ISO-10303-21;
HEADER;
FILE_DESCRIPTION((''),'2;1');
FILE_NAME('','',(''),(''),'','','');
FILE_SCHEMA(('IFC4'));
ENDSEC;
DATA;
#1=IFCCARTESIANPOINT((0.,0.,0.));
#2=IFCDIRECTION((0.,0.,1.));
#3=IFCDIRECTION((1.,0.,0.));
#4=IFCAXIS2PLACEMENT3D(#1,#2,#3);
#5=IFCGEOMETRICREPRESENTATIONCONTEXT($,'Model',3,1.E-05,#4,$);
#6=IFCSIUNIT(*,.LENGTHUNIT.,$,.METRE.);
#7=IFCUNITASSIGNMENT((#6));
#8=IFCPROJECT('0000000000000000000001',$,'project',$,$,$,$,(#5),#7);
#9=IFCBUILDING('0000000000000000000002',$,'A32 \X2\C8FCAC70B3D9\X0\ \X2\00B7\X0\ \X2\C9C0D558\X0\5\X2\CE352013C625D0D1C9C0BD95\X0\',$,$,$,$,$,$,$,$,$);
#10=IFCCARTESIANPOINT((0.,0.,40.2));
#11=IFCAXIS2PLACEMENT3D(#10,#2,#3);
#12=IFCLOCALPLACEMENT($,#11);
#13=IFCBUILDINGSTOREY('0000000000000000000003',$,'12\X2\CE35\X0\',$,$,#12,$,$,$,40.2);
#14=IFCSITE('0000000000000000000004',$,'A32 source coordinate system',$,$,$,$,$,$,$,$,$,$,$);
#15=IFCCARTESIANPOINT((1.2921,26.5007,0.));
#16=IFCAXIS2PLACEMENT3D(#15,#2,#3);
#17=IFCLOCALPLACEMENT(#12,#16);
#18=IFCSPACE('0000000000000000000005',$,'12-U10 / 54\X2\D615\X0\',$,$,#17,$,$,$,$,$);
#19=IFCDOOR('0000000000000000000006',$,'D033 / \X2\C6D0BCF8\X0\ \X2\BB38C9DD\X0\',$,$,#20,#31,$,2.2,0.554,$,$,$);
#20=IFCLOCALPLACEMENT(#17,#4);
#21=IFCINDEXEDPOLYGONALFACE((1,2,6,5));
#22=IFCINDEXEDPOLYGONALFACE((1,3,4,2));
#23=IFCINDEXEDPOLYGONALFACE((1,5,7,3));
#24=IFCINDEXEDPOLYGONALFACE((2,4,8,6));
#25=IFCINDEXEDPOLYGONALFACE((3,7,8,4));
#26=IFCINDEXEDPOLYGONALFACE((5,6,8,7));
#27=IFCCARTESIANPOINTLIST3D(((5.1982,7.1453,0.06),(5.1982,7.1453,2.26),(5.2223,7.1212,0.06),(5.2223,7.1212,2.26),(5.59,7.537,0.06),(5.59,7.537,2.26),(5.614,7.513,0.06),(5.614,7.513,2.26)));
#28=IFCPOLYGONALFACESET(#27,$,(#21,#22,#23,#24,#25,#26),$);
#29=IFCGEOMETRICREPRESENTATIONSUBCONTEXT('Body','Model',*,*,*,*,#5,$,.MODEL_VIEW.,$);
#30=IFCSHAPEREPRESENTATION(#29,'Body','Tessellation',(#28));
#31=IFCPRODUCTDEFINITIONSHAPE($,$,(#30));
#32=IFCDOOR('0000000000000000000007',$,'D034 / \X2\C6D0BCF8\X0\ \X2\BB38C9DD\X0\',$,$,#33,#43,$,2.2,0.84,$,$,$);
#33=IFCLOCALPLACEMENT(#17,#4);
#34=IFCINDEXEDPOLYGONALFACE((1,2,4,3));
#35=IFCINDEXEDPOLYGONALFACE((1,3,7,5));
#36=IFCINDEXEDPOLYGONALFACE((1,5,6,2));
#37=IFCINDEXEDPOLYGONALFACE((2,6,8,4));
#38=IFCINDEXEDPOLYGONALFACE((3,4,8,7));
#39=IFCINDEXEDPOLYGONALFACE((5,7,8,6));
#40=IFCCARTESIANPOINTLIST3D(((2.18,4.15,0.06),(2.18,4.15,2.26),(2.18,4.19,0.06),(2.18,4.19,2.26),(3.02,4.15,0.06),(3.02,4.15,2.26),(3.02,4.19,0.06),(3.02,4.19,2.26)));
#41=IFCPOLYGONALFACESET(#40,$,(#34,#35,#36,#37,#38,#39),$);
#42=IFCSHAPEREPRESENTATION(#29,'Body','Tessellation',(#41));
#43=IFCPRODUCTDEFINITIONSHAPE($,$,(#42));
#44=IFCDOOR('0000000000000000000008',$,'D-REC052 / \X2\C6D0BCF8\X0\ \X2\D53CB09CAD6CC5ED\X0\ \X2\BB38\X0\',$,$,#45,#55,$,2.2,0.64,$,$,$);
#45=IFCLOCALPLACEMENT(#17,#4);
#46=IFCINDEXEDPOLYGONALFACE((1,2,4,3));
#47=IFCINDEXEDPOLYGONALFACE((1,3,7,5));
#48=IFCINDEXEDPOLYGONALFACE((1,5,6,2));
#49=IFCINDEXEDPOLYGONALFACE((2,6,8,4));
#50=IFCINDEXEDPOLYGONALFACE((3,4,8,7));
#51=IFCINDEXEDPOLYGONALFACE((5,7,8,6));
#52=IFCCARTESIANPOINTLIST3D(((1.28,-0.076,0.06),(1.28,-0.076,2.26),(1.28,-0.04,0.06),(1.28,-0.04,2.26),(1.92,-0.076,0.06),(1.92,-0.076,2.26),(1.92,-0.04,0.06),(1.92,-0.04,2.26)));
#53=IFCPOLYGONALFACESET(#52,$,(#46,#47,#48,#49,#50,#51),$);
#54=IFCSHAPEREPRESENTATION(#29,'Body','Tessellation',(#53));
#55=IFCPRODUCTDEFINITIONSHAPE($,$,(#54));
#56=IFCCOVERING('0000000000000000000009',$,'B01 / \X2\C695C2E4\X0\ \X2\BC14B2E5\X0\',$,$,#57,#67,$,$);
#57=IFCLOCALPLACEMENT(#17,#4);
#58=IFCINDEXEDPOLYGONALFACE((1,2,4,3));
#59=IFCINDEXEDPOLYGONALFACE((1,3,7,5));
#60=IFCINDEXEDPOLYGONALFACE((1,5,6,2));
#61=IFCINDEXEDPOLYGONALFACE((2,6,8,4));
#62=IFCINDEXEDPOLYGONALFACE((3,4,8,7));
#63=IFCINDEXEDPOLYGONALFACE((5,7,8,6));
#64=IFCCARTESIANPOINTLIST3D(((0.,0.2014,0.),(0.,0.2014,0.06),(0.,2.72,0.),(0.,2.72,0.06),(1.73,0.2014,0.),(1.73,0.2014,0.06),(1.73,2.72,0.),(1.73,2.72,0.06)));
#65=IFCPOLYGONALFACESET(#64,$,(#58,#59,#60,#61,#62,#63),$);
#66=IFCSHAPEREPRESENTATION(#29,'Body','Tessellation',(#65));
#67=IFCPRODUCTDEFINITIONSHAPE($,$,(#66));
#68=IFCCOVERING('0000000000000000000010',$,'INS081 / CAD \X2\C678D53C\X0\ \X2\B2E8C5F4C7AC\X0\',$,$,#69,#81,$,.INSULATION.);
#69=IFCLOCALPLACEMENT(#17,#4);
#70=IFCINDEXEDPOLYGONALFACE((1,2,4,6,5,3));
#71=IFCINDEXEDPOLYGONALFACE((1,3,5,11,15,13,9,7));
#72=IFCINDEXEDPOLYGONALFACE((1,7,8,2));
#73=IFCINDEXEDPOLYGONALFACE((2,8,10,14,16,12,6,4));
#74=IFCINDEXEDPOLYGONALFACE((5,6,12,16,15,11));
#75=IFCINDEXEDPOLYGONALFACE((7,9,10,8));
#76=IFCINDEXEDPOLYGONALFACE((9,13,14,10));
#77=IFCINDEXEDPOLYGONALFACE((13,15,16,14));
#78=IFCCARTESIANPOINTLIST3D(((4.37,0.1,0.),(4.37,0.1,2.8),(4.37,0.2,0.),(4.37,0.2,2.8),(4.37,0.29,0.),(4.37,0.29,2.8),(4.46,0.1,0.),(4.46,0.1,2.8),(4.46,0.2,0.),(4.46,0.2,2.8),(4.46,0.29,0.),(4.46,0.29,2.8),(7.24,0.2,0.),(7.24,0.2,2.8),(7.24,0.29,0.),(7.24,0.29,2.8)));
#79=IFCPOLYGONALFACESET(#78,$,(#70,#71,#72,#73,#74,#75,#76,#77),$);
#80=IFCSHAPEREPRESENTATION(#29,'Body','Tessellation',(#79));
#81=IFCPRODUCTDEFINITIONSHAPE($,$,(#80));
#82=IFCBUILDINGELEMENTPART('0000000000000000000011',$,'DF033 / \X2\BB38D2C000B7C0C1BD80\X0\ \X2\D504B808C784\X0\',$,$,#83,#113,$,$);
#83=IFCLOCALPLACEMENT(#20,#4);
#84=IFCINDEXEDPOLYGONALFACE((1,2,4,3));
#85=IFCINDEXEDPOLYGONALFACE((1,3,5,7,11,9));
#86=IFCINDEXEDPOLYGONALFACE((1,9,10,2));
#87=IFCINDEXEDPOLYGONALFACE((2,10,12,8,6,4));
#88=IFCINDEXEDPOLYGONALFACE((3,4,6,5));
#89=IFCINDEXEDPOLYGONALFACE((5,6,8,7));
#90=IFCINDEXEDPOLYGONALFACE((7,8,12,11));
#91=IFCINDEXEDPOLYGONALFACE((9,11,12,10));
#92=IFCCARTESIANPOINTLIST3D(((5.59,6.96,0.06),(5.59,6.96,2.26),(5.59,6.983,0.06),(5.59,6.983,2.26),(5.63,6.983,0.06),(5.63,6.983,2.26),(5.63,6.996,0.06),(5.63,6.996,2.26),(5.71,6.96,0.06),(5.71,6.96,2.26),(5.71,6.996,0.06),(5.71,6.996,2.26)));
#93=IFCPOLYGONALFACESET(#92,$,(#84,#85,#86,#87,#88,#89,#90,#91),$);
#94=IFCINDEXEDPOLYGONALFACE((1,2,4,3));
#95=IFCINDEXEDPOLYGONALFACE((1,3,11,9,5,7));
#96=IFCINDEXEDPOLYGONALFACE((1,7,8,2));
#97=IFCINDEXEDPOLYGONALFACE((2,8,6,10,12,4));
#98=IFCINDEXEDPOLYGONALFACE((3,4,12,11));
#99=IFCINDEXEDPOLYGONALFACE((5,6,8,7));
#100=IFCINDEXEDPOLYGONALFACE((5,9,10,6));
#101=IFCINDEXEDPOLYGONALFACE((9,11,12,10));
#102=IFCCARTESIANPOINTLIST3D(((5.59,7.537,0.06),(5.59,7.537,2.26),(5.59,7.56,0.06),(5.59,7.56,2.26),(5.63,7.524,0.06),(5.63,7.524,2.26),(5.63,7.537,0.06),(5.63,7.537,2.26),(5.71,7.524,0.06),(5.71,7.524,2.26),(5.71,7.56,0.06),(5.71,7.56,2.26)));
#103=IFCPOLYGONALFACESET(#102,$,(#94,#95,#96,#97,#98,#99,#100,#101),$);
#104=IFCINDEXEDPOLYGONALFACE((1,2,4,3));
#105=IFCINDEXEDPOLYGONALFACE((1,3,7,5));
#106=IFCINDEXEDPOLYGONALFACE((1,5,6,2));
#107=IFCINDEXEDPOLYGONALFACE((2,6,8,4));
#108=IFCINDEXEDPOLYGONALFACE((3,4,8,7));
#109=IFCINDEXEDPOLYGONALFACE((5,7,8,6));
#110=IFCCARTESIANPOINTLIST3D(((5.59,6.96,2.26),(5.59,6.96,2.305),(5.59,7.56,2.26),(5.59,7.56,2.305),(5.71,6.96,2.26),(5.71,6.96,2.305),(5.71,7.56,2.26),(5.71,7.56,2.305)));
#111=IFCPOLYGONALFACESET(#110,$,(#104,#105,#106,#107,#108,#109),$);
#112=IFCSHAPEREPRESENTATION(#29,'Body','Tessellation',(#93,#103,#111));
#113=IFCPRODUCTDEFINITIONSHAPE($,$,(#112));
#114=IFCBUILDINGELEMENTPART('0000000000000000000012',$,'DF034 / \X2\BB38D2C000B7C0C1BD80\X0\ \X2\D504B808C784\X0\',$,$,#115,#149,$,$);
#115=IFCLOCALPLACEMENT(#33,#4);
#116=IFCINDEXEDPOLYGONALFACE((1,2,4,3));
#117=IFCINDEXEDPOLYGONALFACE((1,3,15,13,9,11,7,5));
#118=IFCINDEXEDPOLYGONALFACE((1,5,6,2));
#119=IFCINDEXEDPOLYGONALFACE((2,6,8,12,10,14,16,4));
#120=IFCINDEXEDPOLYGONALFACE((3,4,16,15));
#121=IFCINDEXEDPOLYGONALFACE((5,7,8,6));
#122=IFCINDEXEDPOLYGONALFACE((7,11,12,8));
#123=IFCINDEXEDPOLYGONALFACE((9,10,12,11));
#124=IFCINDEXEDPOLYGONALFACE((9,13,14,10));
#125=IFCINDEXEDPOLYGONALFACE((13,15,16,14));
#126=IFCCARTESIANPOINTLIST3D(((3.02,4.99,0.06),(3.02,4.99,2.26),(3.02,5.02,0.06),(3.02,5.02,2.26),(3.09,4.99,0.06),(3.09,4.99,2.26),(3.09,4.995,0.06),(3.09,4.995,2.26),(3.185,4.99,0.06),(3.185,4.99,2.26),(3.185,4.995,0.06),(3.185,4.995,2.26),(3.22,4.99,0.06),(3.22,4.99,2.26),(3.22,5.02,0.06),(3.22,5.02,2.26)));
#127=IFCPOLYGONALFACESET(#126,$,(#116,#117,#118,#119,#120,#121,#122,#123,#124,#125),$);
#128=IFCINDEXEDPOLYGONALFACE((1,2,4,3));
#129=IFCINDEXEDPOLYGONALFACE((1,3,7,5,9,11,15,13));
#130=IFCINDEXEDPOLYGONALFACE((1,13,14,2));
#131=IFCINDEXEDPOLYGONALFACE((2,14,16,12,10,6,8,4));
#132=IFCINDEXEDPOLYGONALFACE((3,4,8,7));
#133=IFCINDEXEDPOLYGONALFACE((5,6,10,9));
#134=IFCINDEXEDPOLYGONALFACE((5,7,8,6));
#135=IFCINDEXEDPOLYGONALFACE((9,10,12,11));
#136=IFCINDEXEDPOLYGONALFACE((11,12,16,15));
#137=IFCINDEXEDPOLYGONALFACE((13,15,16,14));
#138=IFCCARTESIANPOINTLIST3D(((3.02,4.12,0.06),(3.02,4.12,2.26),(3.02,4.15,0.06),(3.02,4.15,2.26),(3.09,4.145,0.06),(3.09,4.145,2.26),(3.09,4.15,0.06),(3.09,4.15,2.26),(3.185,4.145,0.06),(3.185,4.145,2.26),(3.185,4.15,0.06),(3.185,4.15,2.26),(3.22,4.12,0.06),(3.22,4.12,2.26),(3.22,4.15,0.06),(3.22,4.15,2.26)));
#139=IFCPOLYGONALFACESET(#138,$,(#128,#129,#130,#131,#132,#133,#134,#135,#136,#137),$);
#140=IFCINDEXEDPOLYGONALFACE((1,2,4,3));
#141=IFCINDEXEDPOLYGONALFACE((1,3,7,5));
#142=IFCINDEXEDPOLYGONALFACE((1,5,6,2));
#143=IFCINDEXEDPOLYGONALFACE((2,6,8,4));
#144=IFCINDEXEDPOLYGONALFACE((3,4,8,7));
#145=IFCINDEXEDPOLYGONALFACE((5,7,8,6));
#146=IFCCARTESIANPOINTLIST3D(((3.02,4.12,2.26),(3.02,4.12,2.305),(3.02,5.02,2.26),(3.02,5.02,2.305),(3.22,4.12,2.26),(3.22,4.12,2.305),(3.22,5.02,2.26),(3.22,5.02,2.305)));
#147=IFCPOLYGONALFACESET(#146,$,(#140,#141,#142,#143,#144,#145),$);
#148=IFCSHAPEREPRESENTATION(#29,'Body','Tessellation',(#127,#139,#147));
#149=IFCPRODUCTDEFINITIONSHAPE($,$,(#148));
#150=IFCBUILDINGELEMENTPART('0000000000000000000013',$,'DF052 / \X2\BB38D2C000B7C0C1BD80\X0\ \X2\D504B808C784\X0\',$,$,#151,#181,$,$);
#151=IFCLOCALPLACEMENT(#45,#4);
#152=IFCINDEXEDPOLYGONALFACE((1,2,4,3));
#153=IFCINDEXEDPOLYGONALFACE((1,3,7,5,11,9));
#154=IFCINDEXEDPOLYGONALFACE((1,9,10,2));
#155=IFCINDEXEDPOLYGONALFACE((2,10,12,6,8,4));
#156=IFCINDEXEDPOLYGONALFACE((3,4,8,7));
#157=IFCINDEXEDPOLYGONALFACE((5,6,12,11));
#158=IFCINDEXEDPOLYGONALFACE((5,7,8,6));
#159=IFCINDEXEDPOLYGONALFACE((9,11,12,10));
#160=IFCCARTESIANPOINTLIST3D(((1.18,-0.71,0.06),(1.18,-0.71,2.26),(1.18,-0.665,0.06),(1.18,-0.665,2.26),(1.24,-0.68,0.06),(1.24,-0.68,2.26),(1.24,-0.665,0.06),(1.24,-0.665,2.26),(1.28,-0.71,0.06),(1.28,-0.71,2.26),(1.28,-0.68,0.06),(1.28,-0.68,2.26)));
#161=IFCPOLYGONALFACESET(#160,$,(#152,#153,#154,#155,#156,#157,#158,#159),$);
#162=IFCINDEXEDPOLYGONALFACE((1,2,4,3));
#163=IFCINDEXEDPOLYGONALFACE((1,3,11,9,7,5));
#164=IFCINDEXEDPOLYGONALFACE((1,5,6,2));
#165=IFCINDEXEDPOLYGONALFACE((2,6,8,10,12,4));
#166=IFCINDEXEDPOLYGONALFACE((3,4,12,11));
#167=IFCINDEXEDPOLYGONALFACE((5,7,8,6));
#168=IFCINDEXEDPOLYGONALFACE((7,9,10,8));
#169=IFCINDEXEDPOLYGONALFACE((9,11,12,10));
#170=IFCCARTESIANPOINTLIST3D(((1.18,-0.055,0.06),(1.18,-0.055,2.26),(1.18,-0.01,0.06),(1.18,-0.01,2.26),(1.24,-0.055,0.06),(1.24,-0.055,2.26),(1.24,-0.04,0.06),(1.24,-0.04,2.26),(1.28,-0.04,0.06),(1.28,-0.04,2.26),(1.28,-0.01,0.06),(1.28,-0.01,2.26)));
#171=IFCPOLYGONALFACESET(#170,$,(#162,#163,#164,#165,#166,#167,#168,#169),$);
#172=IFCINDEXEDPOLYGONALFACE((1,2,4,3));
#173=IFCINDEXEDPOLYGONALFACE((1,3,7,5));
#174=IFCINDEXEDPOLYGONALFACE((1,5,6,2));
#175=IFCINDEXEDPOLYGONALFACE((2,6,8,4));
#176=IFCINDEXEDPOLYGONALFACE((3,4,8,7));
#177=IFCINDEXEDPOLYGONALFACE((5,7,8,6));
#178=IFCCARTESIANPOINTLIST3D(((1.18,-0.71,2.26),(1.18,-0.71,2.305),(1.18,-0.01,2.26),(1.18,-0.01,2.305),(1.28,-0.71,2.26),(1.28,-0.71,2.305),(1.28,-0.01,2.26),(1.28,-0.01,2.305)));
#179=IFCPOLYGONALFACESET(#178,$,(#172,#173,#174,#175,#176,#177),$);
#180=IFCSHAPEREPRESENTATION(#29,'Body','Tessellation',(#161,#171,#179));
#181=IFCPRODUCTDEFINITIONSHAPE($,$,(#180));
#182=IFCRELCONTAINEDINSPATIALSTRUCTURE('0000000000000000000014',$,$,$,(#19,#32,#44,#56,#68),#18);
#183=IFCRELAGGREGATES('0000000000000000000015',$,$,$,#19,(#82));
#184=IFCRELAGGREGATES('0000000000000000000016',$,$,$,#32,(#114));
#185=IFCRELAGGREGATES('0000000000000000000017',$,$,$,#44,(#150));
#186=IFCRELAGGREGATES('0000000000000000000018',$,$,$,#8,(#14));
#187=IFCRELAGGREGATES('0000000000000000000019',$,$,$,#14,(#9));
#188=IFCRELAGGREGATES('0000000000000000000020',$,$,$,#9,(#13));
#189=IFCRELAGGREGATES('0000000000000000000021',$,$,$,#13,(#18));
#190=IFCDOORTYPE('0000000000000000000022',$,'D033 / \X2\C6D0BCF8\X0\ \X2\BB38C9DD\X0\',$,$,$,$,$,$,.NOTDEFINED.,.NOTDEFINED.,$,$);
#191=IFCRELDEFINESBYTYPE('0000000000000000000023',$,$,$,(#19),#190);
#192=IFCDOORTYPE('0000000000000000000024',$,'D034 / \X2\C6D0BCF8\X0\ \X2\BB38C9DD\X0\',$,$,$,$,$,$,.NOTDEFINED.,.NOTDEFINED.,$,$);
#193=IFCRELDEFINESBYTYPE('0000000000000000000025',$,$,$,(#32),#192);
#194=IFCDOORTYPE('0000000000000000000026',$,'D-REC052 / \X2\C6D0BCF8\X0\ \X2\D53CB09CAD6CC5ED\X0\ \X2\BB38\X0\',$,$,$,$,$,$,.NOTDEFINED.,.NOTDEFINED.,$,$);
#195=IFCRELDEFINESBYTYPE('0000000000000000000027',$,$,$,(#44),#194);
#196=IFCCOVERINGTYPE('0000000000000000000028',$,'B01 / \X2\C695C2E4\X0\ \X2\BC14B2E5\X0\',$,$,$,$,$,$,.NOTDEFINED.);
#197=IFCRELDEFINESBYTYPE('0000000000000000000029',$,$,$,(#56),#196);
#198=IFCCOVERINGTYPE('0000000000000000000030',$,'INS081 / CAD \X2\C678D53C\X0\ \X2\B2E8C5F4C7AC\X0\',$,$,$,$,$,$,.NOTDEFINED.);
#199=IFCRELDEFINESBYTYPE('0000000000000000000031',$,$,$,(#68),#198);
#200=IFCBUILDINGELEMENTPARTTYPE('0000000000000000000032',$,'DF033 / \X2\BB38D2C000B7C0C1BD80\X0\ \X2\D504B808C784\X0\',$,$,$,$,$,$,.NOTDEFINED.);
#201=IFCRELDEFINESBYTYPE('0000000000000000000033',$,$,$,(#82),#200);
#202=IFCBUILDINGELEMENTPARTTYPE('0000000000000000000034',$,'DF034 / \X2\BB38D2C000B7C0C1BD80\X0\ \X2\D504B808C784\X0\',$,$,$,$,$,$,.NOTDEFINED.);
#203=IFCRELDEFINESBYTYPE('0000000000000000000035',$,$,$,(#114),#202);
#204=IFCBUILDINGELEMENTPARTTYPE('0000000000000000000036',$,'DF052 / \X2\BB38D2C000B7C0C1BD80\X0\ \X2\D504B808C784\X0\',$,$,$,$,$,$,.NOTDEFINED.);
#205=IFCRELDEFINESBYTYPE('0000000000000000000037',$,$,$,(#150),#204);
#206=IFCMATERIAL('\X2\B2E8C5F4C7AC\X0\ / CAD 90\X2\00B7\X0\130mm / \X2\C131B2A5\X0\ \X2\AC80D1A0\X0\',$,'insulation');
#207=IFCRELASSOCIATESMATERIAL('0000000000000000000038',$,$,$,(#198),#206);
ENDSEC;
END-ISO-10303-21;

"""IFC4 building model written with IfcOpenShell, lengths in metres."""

from ifc_helpers import new_model, si_unit, frame, origin, origin_with_axes, place, context, subcontext, project, spatial, polyline, outline, extrude, source, transform, mapped, material, type_object, type_shapes, element, aggregate, save


model = new_model("IFC4")

# Units and contexts
model_context = context("Model", 3, precision=1e-05, world=origin_with_axes())
body_context = subcontext(model_context, "Body", "Model", "MODEL_VIEW")
ifc_project = project(units=[si_unit("LENGTHUNIT", "METRE")], contexts=[model_context])

# Site, building, storey, space
storey_placement = place(None, frame((0.0, 0.0, 40.2), z_axis=(0.0, 0.0, 1.0), x_axis=(1.0, 0.0, 0.0)))
space_placement = place(storey_placement, frame((1.2921, 26.5007, 0.0), z_axis=(0.0, 0.0, 1.0), x_axis=(1.0, 0.0, 0.0)))
site = spatial("IfcSite", under=ifc_project, Name="A32 source coordinate system")
building = spatial("IfcBuilding", under=site, Name="A32 주거동 · 지하5층–옥탑지붕")
storey = spatial("IfcBuildingStorey", under=building, at=storey_placement, Name="12층", Elevation=40.2)
space = spatial("IfcSpace", under=storey, at=space_placement, Name="12-U10 / 54형")

# Doors
door_type_1 = type_object("IfcDoorType", Name="D033 / 원본 문짝", OperationType="NOTDEFINED", PredefinedType="NOTDEFINED")
shared_shape_1 = source(origin(), body_context, "Body", "SweptSolid", [
    extrude(outline(polyline([(5.2223, 7.1212), (5.1982, 7.1453), (5.59, 7.537), (5.614, 7.513), (5.2223, 7.1212)])), frame((0.0, 0.0, 0.06)), (0.0, 0.0, 1.0), 2.2),
])
type_shapes(door_type_1, [shared_shape_1])
door_1_placement = place(space_placement, origin_with_axes())
door_1 = element("IfcDoor", 1, at=door_1_placement, inside=space, type_object=door_type_1, Name="D033 / 원본 문짝", OverallHeight=2.2, OverallWidth=0.554, context=body_context, shape_type="MappedRepresentation", body=[
    mapped(shared_shape_1, transform((0.0, 0.0, 0.0), scale=1.0)),
])
door_type_2 = type_object("IfcDoorType", Name="D034 / 원본 문짝", OperationType="NOTDEFINED", PredefinedType="NOTDEFINED")
shared_shape_2 = source(origin(), body_context, "Body", "SweptSolid", [
    extrude(outline(polyline([(3.02, 4.15), (2.18, 4.15), (2.18, 4.19), (3.02, 4.19), (3.02, 4.15)])), frame((0.0, 0.0, 0.06)), (0.0, 0.0, 1.0), 2.2),
])
type_shapes(door_type_2, [shared_shape_2])
door_2_placement = place(space_placement, origin_with_axes())
door_2 = element("IfcDoor", 2, at=door_2_placement, inside=space, type_object=door_type_2, Name="D034 / 원본 문짝", OverallHeight=2.2, OverallWidth=0.84, context=body_context, shape_type="MappedRepresentation", body=[
    mapped(shared_shape_2, transform((0.0, 0.0, 0.0), scale=1.0)),
])
door_type_3 = type_object("IfcDoorType", Name="D-REC052 / 원본 피난구역 문", OperationType="NOTDEFINED", PredefinedType="NOTDEFINED")
shared_shape_3 = source(origin(), body_context, "Body", "SweptSolid", [
    extrude(outline(polyline([(1.92, -0.076), (1.28, -0.076), (1.28, -0.04), (1.92, -0.04), (1.92, -0.076)])), frame((0.0, 0.0, 0.06)), (0.0, 0.0, 1.0), 2.2),
])
type_shapes(door_type_3, [shared_shape_3])
door_3_placement = place(space_placement, origin_with_axes())
door_3 = element("IfcDoor", 3, at=door_3_placement, inside=space, type_object=door_type_3, Name="D-REC052 / 원본 피난구역 문", OverallHeight=2.2, OverallWidth=0.64, context=body_context, shape_type="MappedRepresentation", body=[
    mapped(shared_shape_3, transform((0.0, 0.0, 0.0), scale=1.0)),
])

# Coverings
covering_type_1 = type_object("IfcCoveringType", Name="B01 / 욕실 바닥", PredefinedType="NOTDEFINED")
shared_shape_4 = source(origin(), body_context, "Body", "SweptSolid", [
    extrude(outline(polyline([(0.0, 0.2014), (0.0, 2.72), (1.73, 2.72), (1.73, 0.2014), (0.0, 0.2014)])), origin(), (0.0, 0.0, 1.0), 0.06),
])
type_shapes(covering_type_1, [shared_shape_4])
covering_1_placement = place(space_placement, origin_with_axes())
element("IfcCovering", 4, at=covering_1_placement, inside=space, type_object=covering_type_1, Name="B01 / 욕실 바닥", context=body_context, shape_type="MappedRepresentation", body=[
    mapped(shared_shape_4, transform((0.0, 0.0, 0.0), scale=1.0)),
])
ifc_material = material(Name="단열재 / CAD 90·130mm / 성능 검토", Category="insulation")
covering_type_2 = type_object("IfcCoveringType", Name="INS081 / CAD 외피 단열재", PredefinedType="NOTDEFINED", material=ifc_material)
shared_shape_5 = source(origin(), body_context, "Body", "SweptSolid", [
    extrude(outline(polyline([(4.37, 0.2), (4.37, 0.29), (4.46, 0.29), (7.24, 0.29), (7.24, 0.2), (4.46, 0.2), (4.46, 0.1), (4.37, 0.1), (4.37, 0.2)])), origin(), (0.0, 0.0, 1.0), 2.8),
])
type_shapes(covering_type_2, [shared_shape_5])
covering_2_placement = place(space_placement, origin_with_axes())
element("IfcCovering", 5, at=covering_2_placement, inside=space, type_object=covering_type_2, Name="INS081 / CAD 외피 단열재", PredefinedType="INSULATION", context=body_context, shape_type="MappedRepresentation", body=[
    mapped(shared_shape_5, transform((0.0, 0.0, 0.0), scale=1.0)),
])

# Building element parts
building_element_part_type_1 = type_object("IfcBuildingElementPartType", Name="DF033 / 문틀·상부 프레임", PredefinedType="NOTDEFINED")
shared_shape_6 = source(origin(), body_context, "Body", "SweptSolid", [
    extrude(outline(polyline([(5.59, 6.96), (5.59, 6.983), (5.63, 6.983), (5.63, 6.996), (5.71, 6.996), (5.71, 6.96), (5.59, 6.96)])), frame((0.0, 0.0, 0.06)), (0.0, 0.0, 1.0), 2.2),
    extrude(outline(polyline([(5.71, 7.524), (5.63, 7.524), (5.63, 7.537), (5.59, 7.537), (5.59, 7.56), (5.71, 7.56), (5.71, 7.524)])), frame((0.0, 0.0, 0.06)), (0.0, 0.0, 1.0), 2.2),
    extrude(outline(polyline([(5.59, 6.96), (5.59, 7.56), (5.71, 7.56), (5.71, 6.96), (5.59, 6.96)])), frame((0.0, 0.0, 2.26)), (0.0, 0.0, 1.0), 0.045),
])
type_shapes(building_element_part_type_1, [shared_shape_6])
building_element_part_1_placement = place(door_1_placement, origin_with_axes())
building_element_part_1 = element("IfcBuildingElementPart", 6, at=building_element_part_1_placement, type_object=building_element_part_type_1, Name="DF033 / 문틀·상부 프레임", context=body_context, shape_type="MappedRepresentation", body=[
    mapped(shared_shape_6, transform((0.0, 0.0, 0.0), scale=1.0)),
])
aggregate(door_1, [building_element_part_1])
building_element_part_type_2 = type_object("IfcBuildingElementPartType", Name="DF034 / 문틀·상부 프레임", PredefinedType="NOTDEFINED")
shared_shape_7 = source(origin(), body_context, "Body", "SweptSolid", [
    extrude(outline(polyline([(3.22, 5.02), (3.22, 4.99), (3.185, 4.99), (3.185, 4.995), (3.09, 4.995), (3.09, 4.99), (3.02, 4.99), (3.02, 5.02), (3.22, 5.02)])), frame((0.0, 0.0, 0.06)), (0.0, 0.0, 1.0), 2.2),
    extrude(outline(polyline([(3.02, 4.15), (3.09, 4.15), (3.09, 4.145), (3.185, 4.145), (3.185, 4.15), (3.22, 4.15), (3.22, 4.12), (3.02, 4.12), (3.02, 4.15)])), frame((0.0, 0.0, 0.06)), (0.0, 0.0, 1.0), 2.2),
    extrude(outline(polyline([(3.02, 4.12), (3.02, 5.02), (3.22, 5.02), (3.22, 4.12), (3.02, 4.12)])), frame((0.0, 0.0, 2.26)), (0.0, 0.0, 1.0), 0.045),
])
type_shapes(building_element_part_type_2, [shared_shape_7])
building_element_part_2_placement = place(door_2_placement, origin_with_axes())
building_element_part_2 = element("IfcBuildingElementPart", 7, at=building_element_part_2_placement, type_object=building_element_part_type_2, Name="DF034 / 문틀·상부 프레임", context=body_context, shape_type="MappedRepresentation", body=[
    mapped(shared_shape_7, transform((0.0, 0.0, 0.0), scale=1.0)),
])
aggregate(door_2, [building_element_part_2])
building_element_part_type_3 = type_object("IfcBuildingElementPartType", Name="DF052 / 문틀·상부 프레임", PredefinedType="NOTDEFINED")
shared_shape_8 = source(origin(), body_context, "Body", "SweptSolid", [
    extrude(outline(polyline([(1.18, -0.71), (1.18, -0.665), (1.24, -0.665), (1.24, -0.68), (1.28, -0.68), (1.28, -0.71), (1.18, -0.71)])), frame((0.0, 0.0, 0.06)), (0.0, 0.0, 1.0), 2.2),
    extrude(outline(polyline([(1.28, -0.04), (1.24, -0.04), (1.24, -0.055), (1.18, -0.055), (1.18, -0.01), (1.28, -0.01), (1.28, -0.04)])), frame((0.0, 0.0, 0.06)), (0.0, 0.0, 1.0), 2.2),
    extrude(outline(polyline([(1.18, -0.71), (1.18, -0.01), (1.28, -0.01), (1.28, -0.71), (1.18, -0.71)])), frame((0.0, 0.0, 2.26)), (0.0, 0.0, 1.0), 0.045),
])
type_shapes(building_element_part_type_3, [shared_shape_8])
building_element_part_3_placement = place(door_3_placement, origin_with_axes())
building_element_part_3 = element("IfcBuildingElementPart", 8, at=building_element_part_3_placement, type_object=building_element_part_type_3, Name="DF052 / 문틀·상부 프레임", context=body_context, shape_type="MappedRepresentation", body=[
    mapped(shared_shape_8, transform((0.0, 0.0, 0.0), scale=1.0)),
])
aggregate(door_3, [building_element_part_3])

save(model, "model.ifc")
